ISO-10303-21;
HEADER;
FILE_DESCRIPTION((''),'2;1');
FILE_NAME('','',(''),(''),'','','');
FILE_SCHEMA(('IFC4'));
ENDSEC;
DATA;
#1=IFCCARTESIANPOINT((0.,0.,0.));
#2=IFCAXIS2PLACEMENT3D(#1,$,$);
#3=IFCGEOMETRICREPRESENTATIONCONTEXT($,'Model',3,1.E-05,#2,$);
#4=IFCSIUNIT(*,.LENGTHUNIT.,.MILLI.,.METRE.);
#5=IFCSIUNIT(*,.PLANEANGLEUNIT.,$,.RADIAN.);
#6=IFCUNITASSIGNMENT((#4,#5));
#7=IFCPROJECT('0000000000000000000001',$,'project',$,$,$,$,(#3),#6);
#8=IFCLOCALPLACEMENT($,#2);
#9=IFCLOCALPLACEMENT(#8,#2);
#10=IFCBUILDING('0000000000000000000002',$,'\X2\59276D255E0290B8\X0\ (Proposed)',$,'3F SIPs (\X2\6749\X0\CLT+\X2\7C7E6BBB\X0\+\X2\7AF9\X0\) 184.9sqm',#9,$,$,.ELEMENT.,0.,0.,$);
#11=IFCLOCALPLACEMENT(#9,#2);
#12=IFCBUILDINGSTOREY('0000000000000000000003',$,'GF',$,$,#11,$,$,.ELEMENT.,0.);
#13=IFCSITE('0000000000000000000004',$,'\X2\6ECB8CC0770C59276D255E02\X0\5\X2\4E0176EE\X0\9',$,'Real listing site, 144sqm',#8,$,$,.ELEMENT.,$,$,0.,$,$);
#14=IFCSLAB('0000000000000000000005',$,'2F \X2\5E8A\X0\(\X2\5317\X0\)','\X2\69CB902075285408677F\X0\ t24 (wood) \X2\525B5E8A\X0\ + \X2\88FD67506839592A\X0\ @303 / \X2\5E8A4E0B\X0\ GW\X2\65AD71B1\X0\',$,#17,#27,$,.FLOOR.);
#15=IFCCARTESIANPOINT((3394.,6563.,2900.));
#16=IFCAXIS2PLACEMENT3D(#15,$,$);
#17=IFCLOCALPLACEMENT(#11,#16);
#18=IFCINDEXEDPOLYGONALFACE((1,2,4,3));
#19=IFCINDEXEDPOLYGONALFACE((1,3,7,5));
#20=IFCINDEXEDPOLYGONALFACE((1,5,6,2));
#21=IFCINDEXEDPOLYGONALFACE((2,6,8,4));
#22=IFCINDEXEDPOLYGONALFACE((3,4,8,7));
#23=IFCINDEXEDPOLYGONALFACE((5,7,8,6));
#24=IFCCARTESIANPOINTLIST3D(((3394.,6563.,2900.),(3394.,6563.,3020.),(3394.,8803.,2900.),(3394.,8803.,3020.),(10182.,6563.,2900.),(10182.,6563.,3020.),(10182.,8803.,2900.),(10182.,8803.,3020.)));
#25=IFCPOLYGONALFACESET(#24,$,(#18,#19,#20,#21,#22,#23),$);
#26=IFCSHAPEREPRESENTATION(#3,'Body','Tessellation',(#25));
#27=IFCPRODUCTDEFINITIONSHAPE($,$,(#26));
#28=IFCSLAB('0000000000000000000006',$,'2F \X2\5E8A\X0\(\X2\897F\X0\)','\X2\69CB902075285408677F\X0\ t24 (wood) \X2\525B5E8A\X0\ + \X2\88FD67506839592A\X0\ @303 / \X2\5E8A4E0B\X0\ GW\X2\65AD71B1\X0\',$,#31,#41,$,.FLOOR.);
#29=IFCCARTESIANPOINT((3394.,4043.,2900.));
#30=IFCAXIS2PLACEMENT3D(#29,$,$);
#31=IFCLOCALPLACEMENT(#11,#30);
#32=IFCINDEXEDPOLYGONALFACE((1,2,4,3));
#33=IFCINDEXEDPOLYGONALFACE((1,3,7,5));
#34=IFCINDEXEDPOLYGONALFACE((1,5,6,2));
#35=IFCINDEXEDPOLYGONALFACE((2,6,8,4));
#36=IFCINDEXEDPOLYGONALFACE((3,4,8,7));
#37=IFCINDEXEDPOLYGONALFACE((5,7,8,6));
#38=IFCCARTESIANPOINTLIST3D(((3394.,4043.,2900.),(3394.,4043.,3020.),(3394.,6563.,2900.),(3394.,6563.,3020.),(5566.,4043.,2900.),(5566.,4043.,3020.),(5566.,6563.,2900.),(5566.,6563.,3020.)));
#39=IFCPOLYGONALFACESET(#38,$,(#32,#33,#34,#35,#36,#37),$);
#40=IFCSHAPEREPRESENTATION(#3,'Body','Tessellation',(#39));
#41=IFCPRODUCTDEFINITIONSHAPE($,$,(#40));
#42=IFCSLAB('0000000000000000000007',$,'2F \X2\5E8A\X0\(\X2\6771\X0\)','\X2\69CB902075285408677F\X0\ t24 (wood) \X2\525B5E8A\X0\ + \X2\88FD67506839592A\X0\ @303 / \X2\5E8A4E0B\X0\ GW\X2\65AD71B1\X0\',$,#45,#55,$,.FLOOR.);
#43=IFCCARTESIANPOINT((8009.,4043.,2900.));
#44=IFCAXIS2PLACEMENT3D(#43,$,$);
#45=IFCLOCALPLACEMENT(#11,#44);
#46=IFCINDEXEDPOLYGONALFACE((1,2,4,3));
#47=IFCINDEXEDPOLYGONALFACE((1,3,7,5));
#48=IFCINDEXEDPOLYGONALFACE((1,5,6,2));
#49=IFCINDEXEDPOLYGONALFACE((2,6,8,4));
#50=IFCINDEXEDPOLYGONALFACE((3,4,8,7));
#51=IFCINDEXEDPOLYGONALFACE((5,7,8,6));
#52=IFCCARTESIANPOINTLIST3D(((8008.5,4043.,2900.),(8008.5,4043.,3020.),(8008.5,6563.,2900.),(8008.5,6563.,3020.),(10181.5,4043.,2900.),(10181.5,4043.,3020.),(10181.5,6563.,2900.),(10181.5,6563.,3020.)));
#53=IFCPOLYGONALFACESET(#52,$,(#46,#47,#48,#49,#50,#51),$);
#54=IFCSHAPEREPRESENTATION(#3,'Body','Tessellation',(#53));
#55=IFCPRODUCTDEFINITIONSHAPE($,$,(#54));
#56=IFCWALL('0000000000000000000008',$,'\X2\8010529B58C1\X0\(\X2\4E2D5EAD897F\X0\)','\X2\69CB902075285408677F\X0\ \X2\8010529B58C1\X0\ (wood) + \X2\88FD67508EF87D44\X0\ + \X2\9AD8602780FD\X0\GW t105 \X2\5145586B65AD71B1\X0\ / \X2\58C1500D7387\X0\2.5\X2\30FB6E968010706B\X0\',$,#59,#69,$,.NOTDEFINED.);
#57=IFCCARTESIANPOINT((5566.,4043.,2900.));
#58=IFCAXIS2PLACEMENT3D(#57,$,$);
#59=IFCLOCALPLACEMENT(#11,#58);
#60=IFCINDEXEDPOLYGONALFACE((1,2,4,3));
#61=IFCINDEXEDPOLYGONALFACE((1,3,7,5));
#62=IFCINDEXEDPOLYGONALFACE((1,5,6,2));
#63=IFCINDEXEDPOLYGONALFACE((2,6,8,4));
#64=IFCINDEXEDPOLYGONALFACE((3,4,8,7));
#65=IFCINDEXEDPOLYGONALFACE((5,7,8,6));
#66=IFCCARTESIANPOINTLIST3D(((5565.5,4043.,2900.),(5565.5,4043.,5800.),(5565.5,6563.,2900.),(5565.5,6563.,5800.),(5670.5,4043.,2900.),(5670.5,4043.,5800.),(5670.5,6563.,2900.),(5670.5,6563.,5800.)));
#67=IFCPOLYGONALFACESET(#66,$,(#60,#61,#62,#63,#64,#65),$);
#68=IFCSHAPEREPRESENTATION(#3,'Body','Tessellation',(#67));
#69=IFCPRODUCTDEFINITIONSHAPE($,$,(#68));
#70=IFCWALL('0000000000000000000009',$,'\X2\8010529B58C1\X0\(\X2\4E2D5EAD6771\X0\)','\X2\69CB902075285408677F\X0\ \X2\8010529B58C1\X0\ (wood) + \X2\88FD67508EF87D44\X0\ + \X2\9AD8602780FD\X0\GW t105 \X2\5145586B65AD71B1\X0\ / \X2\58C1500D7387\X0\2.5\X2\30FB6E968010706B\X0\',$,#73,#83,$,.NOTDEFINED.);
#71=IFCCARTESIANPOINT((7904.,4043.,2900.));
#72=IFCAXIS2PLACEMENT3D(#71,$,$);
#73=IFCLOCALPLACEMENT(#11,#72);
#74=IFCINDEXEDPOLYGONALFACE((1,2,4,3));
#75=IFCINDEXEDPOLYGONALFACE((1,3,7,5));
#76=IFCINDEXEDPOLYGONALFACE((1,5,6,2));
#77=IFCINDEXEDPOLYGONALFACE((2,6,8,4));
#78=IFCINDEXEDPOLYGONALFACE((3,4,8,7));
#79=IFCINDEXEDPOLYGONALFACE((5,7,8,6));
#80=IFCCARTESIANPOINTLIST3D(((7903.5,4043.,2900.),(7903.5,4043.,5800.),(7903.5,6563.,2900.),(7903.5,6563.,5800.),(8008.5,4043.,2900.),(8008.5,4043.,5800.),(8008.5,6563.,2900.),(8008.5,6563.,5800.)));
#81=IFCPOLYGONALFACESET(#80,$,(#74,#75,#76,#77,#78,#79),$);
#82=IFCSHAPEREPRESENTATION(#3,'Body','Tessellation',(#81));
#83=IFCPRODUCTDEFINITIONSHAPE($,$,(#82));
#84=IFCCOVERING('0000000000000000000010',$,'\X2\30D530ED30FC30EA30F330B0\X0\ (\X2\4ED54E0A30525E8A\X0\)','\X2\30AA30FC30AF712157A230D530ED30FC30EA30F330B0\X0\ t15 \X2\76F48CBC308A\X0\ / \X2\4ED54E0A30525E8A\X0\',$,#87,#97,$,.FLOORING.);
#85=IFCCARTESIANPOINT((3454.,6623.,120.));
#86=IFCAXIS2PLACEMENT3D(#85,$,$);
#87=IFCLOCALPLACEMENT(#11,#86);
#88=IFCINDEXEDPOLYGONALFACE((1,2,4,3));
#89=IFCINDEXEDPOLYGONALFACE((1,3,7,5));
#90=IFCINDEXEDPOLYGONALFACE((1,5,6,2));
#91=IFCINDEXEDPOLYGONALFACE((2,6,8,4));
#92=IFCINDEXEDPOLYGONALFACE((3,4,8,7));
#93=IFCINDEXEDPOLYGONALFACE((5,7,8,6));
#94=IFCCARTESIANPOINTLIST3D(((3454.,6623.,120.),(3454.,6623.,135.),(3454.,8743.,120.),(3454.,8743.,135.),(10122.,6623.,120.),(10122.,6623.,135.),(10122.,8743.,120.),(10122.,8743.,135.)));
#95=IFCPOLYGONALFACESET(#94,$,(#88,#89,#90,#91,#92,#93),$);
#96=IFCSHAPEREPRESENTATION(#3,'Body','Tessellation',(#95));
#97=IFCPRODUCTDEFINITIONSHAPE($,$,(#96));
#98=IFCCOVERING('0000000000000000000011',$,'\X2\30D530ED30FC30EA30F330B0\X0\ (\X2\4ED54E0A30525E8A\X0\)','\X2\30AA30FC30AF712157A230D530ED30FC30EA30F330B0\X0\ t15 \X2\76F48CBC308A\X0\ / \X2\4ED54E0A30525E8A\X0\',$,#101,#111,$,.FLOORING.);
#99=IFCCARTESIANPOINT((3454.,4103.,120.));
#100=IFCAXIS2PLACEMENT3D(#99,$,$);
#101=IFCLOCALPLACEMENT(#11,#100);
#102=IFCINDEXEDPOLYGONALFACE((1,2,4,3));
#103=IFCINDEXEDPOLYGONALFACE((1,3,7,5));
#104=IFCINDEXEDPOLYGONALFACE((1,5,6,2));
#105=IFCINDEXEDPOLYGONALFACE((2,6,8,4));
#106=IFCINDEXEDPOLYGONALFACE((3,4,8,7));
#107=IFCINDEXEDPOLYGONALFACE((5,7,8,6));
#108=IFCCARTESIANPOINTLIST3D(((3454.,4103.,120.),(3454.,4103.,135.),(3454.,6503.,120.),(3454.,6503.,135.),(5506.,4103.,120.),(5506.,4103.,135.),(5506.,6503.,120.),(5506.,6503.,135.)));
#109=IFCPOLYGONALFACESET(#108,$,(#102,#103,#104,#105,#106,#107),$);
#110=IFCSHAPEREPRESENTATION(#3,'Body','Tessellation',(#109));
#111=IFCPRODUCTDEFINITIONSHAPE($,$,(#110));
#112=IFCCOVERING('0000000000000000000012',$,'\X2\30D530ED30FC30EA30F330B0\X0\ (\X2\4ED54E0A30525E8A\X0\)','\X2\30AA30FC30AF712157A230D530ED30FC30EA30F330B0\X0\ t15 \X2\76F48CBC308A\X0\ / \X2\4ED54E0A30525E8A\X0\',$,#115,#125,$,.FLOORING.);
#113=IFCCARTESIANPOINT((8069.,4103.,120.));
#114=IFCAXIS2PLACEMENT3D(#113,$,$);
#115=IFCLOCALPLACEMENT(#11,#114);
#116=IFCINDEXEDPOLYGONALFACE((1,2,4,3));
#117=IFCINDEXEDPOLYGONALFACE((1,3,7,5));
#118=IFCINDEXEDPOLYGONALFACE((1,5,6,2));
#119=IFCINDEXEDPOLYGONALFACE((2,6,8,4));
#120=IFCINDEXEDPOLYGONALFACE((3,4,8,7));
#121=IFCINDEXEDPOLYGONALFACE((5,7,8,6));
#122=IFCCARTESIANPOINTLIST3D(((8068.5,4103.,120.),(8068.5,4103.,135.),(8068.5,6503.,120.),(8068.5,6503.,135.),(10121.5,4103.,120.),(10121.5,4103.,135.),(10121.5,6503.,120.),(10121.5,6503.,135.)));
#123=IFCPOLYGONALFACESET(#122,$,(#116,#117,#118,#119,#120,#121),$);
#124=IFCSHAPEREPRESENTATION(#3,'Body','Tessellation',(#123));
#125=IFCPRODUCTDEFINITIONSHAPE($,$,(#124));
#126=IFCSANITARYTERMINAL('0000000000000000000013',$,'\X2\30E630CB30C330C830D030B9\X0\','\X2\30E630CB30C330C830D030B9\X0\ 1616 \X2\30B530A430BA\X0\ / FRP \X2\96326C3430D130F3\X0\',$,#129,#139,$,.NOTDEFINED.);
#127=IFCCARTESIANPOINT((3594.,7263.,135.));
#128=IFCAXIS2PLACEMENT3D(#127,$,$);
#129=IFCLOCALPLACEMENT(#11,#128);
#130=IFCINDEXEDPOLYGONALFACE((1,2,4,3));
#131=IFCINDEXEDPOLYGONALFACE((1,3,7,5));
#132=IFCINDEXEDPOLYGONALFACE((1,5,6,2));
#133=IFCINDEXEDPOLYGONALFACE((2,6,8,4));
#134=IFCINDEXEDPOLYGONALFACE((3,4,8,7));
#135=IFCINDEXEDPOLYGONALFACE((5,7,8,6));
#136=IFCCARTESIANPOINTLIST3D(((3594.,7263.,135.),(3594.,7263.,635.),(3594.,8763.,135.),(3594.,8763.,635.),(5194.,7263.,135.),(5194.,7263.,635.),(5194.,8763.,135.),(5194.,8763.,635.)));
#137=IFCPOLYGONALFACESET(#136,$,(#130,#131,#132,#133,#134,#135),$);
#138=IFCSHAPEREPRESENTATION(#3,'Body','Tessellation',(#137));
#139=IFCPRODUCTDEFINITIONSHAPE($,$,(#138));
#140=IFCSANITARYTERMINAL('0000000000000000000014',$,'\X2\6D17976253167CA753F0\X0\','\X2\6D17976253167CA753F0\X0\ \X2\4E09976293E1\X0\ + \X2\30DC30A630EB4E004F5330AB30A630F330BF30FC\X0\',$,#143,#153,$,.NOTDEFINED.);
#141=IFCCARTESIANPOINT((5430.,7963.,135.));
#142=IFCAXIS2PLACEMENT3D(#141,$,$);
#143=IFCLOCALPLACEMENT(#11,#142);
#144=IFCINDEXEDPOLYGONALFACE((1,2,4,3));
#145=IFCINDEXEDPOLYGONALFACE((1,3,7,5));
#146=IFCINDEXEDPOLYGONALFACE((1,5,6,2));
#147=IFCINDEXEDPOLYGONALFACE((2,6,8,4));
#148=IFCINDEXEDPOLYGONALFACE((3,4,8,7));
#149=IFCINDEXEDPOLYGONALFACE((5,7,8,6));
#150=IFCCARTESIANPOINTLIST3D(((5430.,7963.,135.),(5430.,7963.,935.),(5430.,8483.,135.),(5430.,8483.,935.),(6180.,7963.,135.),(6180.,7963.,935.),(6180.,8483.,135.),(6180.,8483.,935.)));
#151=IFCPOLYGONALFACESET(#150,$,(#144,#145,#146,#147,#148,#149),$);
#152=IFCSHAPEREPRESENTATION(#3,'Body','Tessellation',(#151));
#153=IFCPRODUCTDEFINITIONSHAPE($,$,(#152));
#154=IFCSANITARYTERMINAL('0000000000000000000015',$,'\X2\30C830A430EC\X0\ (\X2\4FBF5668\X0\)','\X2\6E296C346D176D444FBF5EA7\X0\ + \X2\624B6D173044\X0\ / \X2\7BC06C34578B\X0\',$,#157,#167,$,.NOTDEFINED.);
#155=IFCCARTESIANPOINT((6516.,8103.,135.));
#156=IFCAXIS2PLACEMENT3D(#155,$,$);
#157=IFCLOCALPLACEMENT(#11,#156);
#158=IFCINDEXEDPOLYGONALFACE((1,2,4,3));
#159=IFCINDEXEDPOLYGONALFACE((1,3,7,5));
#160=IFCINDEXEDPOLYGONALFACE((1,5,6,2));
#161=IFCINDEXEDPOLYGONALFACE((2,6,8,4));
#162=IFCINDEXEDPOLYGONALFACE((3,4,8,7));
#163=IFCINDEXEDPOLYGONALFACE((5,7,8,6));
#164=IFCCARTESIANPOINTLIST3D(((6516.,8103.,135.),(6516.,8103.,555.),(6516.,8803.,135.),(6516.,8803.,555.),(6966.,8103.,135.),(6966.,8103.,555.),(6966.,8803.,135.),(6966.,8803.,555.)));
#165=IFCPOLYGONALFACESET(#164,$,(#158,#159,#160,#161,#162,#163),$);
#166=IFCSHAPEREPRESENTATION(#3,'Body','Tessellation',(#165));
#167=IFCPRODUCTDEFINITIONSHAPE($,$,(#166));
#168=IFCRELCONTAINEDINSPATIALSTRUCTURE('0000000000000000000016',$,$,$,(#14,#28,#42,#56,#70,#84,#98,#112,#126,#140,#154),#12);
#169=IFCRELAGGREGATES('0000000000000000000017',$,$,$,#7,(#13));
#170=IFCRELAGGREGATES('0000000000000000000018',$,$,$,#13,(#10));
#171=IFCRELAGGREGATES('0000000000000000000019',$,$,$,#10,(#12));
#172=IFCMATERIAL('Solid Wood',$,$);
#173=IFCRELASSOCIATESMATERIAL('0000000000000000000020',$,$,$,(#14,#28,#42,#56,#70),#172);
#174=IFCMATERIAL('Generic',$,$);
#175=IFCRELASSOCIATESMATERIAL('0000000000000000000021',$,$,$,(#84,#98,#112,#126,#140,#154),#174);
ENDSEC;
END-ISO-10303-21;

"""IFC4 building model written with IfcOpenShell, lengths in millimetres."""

from ifc_helpers import new_model, si_unit, frame, frame_2d, origin, place, context, project, spatial, rectangle, extrude, material, element, save


model = new_model("IFC4")

# Units and contexts
model_context = context("Model", 3, precision=1e-05, world=origin())
ifc_project = project(units=[si_unit("LENGTHUNIT", "METRE", prefix="MILLI"), si_unit("PLANEANGLEUNIT", "RADIAN")], contexts=[model_context])

# Site, building, storey
site_placement = place(None, origin())
site = spatial("IfcSite", under=ifc_project, at=site_placement, Name="滋賀県大津市5丁目9", ObjectType="Real listing site, 144sqm", CompositionType="ELEMENT", RefElevation=0.0)
building_placement = place(site_placement, origin())
building = spatial("IfcBuilding", under=site, at=building_placement, Name="大津市邸 (Proposed)", ObjectType="3F SIPs (杉CLT+籾殻+竹) 184.9sqm", CompositionType="ELEMENT", ElevationOfRefHeight=0.0, ElevationOfTerrain=0.0)
storey_placement = place(building_placement, origin())
storey = spatial("IfcBuildingStorey", under=building, at=storey_placement, Name="GF", CompositionType="ELEMENT", Elevation=0.0)

# Slabs
ifc_material_1 = material(Name="Solid Wood")
slab_1_placement = place(storey_placement, frame((3394.0, 6563.0, 2900.0)))
element("IfcSlab", 1, at=slab_1_placement, inside=storey, material=ifc_material_1, Name="2F 床(北)", Description="構造用合板 t24 (wood) 剛床 + 製材根太 @303 / 床下 GW断熱", PredefinedType="FLOOR", context=model_context, shape_type="SweptSolid", body=[
    extrude(rectangle(XDim=6788.0, YDim=2240.0, at=frame_2d((3394.0, 1120.0))), frame((3394.0, 6563.0, 2900.0)), (0.0, 0.0, 1.0), 120.0),
])
slab_2_placement = place(storey_placement, frame((3394.0, 4043.0, 2900.0)))
element("IfcSlab", 2, at=slab_2_placement, inside=storey, material=ifc_material_1, Name="2F 床(西)", Description="構造用合板 t24 (wood) 剛床 + 製材根太 @303 / 床下 GW断熱", PredefinedType="FLOOR", context=model_context, shape_type="SweptSolid", body=[
    extrude(rectangle(XDim=2172.0, YDim=2520.0, at=frame_2d((1086.0, 1260.0))), frame((3394.0, 4043.0, 2900.0)), (0.0, 0.0, 1.0), 120.0),
])
slab_3_placement = place(storey_placement, frame((8009.0, 4043.0, 2900.0)))
element("IfcSlab", 3, at=slab_3_placement, inside=storey, material=ifc_material_1, Name="2F 床(東)", Description="構造用合板 t24 (wood) 剛床 + 製材根太 @303 / 床下 GW断熱", PredefinedType="FLOOR", context=model_context, shape_type="SweptSolid", body=[
    extrude(rectangle(XDim=2173.0, YDim=2520.0, at=frame_2d((1086.0, 1260.0))), frame((8009.0, 4043.0, 2900.0)), (0.0, 0.0, 1.0), 120.0),
])

# Walls
wall_1_placement = place(storey_placement, frame((5566.0, 4043.0, 2900.0)))
element("IfcWall", 4, at=wall_1_placement, inside=storey, material=ifc_material_1, Name="耐力壁(中庭西)", Description="構造用合板 耐力壁 (wood) + 製材軸組 + 高性能GW t105 充填断熱 / 壁倍率2.5・準耐火", PredefinedType="NOTDEFINED", context=model_context, shape_type="SweptSolid", body=[
    extrude(rectangle(XDim=105.0, YDim=2520.0, at=frame_2d((52.0, 1260.0))), frame((5566.0, 4043.0, 2900.0)), (0.0, 0.0, 1.0), 2900.0),
])
wall_2_placement = place(storey_placement, frame((7904.0, 4043.0, 2900.0)))
element("IfcWall", 5, at=wall_2_placement, inside=storey, material=ifc_material_1, Name="耐力壁(中庭東)", Description="構造用合板 耐力壁 (wood) + 製材軸組 + 高性能GW t105 充填断熱 / 壁倍率2.5・準耐火", PredefinedType="NOTDEFINED", context=model_context, shape_type="SweptSolid", body=[
    extrude(rectangle(XDim=105.0, YDim=2520.0, at=frame_2d((52.0, 1260.0))), frame((7904.0, 4043.0, 2900.0)), (0.0, 0.0, 1.0), 2900.0),
])

# Coverings
ifc_material_2 = material(Name="Generic")
covering_1_placement = place(storey_placement, frame((3454.0, 6623.0, 120.0)))
element("IfcCovering", 6, at=covering_1_placement, inside=storey, material=ifc_material_2, Name="フローリング (仕上げ床)", Description="オーク無垢フローリング t15 直貼り / 仕上げ床", PredefinedType="FLOORING", context=model_context, shape_type="SweptSolid", body=[
    extrude(rectangle(XDim=6668.0, YDim=2120.0, at=frame_2d((3334.0, 1060.0))), frame((3454.0, 6623.0, 120.0)), (0.0, 0.0, 1.0), 15.0),
])
covering_2_placement = place(storey_placement, frame((3454.0, 4103.0, 120.0)))
element("IfcCovering", 7, at=covering_2_placement, inside=storey, material=ifc_material_2, Name="フローリング (仕上げ床)", Description="オーク無垢フローリング t15 直貼り / 仕上げ床", PredefinedType="FLOORING", context=model_context, shape_type="SweptSolid", body=[
    extrude(rectangle(XDim=2052.0, YDim=2400.0, at=frame_2d((1026.0, 1200.0))), frame((3454.0, 4103.0, 120.0)), (0.0, 0.0, 1.0), 15.0),
])
covering_3_placement = place(storey_placement, frame((8069.0, 4103.0, 120.0)))
element("IfcCovering", 8, at=covering_3_placement, inside=storey, material=ifc_material_2, Name="フローリング (仕上げ床)", Description="オーク無垢フローリング t15 直貼り / 仕上げ床", PredefinedType="FLOORING", context=model_context, shape_type="SweptSolid", body=[
    extrude(rectangle(XDim=2053.0, YDim=2400.0, at=frame_2d((1026.0, 1200.0))), frame((8069.0, 4103.0, 120.0)), (0.0, 0.0, 1.0), 15.0),
])

# Sanitary terminals
sanitary_terminal_1_placement = place(storey_placement, frame((3594.0, 7263.0, 135.0)))
element("IfcSanitaryTerminal", 9, at=sanitary_terminal_1_placement, inside=storey, material=ifc_material_2, Name="ユニットバス", Description="ユニットバス 1616 サイズ / FRP 防水パン", PredefinedType="NOTDEFINED", context=model_context, shape_type="SweptSolid", body=[
    extrude(rectangle(XDim=1600.0, YDim=1500.0, at=frame_2d((800.0, 750.0))), frame((3594.0, 7263.0, 135.0)), (0.0, 0.0, 1.0), 500.0),
])
sanitary_terminal_2_placement = place(storey_placement, frame((5430.0, 7963.0, 135.0)))
element("IfcSanitaryTerminal", 10, at=sanitary_terminal_2_placement, inside=storey, material=ifc_material_2, Name="洗面化粧台", Description="洗面化粧台 三面鏡 + ボウル一体カウンター", PredefinedType="NOTDEFINED", context=model_context, shape_type="SweptSolid", body=[
    extrude(rectangle(XDim=750.0, YDim=520.0, at=frame_2d((375.0, 260.0))), frame((5430.0, 7963.0, 135.0)), (0.0, 0.0, 1.0), 800.0),
])
sanitary_terminal_3_placement = place(storey_placement, frame((6516.0, 8103.0, 135.0)))
element("IfcSanitaryTerminal", 11, at=sanitary_terminal_3_placement, inside=storey, material=ifc_material_2, Name="トイレ (便器)", Description="温水洗浄便座 + 手洗い / 節水型", PredefinedType="NOTDEFINED", context=model_context, shape_type="SweptSolid", body=[
    extrude(rectangle(XDim=450.0, YDim=700.0, at=frame_2d((225.0, 350.0))), frame((6516.0, 8103.0, 135.0)), (0.0, 0.0, 1.0), 420.0),
])

save(model, "model.ifc")
